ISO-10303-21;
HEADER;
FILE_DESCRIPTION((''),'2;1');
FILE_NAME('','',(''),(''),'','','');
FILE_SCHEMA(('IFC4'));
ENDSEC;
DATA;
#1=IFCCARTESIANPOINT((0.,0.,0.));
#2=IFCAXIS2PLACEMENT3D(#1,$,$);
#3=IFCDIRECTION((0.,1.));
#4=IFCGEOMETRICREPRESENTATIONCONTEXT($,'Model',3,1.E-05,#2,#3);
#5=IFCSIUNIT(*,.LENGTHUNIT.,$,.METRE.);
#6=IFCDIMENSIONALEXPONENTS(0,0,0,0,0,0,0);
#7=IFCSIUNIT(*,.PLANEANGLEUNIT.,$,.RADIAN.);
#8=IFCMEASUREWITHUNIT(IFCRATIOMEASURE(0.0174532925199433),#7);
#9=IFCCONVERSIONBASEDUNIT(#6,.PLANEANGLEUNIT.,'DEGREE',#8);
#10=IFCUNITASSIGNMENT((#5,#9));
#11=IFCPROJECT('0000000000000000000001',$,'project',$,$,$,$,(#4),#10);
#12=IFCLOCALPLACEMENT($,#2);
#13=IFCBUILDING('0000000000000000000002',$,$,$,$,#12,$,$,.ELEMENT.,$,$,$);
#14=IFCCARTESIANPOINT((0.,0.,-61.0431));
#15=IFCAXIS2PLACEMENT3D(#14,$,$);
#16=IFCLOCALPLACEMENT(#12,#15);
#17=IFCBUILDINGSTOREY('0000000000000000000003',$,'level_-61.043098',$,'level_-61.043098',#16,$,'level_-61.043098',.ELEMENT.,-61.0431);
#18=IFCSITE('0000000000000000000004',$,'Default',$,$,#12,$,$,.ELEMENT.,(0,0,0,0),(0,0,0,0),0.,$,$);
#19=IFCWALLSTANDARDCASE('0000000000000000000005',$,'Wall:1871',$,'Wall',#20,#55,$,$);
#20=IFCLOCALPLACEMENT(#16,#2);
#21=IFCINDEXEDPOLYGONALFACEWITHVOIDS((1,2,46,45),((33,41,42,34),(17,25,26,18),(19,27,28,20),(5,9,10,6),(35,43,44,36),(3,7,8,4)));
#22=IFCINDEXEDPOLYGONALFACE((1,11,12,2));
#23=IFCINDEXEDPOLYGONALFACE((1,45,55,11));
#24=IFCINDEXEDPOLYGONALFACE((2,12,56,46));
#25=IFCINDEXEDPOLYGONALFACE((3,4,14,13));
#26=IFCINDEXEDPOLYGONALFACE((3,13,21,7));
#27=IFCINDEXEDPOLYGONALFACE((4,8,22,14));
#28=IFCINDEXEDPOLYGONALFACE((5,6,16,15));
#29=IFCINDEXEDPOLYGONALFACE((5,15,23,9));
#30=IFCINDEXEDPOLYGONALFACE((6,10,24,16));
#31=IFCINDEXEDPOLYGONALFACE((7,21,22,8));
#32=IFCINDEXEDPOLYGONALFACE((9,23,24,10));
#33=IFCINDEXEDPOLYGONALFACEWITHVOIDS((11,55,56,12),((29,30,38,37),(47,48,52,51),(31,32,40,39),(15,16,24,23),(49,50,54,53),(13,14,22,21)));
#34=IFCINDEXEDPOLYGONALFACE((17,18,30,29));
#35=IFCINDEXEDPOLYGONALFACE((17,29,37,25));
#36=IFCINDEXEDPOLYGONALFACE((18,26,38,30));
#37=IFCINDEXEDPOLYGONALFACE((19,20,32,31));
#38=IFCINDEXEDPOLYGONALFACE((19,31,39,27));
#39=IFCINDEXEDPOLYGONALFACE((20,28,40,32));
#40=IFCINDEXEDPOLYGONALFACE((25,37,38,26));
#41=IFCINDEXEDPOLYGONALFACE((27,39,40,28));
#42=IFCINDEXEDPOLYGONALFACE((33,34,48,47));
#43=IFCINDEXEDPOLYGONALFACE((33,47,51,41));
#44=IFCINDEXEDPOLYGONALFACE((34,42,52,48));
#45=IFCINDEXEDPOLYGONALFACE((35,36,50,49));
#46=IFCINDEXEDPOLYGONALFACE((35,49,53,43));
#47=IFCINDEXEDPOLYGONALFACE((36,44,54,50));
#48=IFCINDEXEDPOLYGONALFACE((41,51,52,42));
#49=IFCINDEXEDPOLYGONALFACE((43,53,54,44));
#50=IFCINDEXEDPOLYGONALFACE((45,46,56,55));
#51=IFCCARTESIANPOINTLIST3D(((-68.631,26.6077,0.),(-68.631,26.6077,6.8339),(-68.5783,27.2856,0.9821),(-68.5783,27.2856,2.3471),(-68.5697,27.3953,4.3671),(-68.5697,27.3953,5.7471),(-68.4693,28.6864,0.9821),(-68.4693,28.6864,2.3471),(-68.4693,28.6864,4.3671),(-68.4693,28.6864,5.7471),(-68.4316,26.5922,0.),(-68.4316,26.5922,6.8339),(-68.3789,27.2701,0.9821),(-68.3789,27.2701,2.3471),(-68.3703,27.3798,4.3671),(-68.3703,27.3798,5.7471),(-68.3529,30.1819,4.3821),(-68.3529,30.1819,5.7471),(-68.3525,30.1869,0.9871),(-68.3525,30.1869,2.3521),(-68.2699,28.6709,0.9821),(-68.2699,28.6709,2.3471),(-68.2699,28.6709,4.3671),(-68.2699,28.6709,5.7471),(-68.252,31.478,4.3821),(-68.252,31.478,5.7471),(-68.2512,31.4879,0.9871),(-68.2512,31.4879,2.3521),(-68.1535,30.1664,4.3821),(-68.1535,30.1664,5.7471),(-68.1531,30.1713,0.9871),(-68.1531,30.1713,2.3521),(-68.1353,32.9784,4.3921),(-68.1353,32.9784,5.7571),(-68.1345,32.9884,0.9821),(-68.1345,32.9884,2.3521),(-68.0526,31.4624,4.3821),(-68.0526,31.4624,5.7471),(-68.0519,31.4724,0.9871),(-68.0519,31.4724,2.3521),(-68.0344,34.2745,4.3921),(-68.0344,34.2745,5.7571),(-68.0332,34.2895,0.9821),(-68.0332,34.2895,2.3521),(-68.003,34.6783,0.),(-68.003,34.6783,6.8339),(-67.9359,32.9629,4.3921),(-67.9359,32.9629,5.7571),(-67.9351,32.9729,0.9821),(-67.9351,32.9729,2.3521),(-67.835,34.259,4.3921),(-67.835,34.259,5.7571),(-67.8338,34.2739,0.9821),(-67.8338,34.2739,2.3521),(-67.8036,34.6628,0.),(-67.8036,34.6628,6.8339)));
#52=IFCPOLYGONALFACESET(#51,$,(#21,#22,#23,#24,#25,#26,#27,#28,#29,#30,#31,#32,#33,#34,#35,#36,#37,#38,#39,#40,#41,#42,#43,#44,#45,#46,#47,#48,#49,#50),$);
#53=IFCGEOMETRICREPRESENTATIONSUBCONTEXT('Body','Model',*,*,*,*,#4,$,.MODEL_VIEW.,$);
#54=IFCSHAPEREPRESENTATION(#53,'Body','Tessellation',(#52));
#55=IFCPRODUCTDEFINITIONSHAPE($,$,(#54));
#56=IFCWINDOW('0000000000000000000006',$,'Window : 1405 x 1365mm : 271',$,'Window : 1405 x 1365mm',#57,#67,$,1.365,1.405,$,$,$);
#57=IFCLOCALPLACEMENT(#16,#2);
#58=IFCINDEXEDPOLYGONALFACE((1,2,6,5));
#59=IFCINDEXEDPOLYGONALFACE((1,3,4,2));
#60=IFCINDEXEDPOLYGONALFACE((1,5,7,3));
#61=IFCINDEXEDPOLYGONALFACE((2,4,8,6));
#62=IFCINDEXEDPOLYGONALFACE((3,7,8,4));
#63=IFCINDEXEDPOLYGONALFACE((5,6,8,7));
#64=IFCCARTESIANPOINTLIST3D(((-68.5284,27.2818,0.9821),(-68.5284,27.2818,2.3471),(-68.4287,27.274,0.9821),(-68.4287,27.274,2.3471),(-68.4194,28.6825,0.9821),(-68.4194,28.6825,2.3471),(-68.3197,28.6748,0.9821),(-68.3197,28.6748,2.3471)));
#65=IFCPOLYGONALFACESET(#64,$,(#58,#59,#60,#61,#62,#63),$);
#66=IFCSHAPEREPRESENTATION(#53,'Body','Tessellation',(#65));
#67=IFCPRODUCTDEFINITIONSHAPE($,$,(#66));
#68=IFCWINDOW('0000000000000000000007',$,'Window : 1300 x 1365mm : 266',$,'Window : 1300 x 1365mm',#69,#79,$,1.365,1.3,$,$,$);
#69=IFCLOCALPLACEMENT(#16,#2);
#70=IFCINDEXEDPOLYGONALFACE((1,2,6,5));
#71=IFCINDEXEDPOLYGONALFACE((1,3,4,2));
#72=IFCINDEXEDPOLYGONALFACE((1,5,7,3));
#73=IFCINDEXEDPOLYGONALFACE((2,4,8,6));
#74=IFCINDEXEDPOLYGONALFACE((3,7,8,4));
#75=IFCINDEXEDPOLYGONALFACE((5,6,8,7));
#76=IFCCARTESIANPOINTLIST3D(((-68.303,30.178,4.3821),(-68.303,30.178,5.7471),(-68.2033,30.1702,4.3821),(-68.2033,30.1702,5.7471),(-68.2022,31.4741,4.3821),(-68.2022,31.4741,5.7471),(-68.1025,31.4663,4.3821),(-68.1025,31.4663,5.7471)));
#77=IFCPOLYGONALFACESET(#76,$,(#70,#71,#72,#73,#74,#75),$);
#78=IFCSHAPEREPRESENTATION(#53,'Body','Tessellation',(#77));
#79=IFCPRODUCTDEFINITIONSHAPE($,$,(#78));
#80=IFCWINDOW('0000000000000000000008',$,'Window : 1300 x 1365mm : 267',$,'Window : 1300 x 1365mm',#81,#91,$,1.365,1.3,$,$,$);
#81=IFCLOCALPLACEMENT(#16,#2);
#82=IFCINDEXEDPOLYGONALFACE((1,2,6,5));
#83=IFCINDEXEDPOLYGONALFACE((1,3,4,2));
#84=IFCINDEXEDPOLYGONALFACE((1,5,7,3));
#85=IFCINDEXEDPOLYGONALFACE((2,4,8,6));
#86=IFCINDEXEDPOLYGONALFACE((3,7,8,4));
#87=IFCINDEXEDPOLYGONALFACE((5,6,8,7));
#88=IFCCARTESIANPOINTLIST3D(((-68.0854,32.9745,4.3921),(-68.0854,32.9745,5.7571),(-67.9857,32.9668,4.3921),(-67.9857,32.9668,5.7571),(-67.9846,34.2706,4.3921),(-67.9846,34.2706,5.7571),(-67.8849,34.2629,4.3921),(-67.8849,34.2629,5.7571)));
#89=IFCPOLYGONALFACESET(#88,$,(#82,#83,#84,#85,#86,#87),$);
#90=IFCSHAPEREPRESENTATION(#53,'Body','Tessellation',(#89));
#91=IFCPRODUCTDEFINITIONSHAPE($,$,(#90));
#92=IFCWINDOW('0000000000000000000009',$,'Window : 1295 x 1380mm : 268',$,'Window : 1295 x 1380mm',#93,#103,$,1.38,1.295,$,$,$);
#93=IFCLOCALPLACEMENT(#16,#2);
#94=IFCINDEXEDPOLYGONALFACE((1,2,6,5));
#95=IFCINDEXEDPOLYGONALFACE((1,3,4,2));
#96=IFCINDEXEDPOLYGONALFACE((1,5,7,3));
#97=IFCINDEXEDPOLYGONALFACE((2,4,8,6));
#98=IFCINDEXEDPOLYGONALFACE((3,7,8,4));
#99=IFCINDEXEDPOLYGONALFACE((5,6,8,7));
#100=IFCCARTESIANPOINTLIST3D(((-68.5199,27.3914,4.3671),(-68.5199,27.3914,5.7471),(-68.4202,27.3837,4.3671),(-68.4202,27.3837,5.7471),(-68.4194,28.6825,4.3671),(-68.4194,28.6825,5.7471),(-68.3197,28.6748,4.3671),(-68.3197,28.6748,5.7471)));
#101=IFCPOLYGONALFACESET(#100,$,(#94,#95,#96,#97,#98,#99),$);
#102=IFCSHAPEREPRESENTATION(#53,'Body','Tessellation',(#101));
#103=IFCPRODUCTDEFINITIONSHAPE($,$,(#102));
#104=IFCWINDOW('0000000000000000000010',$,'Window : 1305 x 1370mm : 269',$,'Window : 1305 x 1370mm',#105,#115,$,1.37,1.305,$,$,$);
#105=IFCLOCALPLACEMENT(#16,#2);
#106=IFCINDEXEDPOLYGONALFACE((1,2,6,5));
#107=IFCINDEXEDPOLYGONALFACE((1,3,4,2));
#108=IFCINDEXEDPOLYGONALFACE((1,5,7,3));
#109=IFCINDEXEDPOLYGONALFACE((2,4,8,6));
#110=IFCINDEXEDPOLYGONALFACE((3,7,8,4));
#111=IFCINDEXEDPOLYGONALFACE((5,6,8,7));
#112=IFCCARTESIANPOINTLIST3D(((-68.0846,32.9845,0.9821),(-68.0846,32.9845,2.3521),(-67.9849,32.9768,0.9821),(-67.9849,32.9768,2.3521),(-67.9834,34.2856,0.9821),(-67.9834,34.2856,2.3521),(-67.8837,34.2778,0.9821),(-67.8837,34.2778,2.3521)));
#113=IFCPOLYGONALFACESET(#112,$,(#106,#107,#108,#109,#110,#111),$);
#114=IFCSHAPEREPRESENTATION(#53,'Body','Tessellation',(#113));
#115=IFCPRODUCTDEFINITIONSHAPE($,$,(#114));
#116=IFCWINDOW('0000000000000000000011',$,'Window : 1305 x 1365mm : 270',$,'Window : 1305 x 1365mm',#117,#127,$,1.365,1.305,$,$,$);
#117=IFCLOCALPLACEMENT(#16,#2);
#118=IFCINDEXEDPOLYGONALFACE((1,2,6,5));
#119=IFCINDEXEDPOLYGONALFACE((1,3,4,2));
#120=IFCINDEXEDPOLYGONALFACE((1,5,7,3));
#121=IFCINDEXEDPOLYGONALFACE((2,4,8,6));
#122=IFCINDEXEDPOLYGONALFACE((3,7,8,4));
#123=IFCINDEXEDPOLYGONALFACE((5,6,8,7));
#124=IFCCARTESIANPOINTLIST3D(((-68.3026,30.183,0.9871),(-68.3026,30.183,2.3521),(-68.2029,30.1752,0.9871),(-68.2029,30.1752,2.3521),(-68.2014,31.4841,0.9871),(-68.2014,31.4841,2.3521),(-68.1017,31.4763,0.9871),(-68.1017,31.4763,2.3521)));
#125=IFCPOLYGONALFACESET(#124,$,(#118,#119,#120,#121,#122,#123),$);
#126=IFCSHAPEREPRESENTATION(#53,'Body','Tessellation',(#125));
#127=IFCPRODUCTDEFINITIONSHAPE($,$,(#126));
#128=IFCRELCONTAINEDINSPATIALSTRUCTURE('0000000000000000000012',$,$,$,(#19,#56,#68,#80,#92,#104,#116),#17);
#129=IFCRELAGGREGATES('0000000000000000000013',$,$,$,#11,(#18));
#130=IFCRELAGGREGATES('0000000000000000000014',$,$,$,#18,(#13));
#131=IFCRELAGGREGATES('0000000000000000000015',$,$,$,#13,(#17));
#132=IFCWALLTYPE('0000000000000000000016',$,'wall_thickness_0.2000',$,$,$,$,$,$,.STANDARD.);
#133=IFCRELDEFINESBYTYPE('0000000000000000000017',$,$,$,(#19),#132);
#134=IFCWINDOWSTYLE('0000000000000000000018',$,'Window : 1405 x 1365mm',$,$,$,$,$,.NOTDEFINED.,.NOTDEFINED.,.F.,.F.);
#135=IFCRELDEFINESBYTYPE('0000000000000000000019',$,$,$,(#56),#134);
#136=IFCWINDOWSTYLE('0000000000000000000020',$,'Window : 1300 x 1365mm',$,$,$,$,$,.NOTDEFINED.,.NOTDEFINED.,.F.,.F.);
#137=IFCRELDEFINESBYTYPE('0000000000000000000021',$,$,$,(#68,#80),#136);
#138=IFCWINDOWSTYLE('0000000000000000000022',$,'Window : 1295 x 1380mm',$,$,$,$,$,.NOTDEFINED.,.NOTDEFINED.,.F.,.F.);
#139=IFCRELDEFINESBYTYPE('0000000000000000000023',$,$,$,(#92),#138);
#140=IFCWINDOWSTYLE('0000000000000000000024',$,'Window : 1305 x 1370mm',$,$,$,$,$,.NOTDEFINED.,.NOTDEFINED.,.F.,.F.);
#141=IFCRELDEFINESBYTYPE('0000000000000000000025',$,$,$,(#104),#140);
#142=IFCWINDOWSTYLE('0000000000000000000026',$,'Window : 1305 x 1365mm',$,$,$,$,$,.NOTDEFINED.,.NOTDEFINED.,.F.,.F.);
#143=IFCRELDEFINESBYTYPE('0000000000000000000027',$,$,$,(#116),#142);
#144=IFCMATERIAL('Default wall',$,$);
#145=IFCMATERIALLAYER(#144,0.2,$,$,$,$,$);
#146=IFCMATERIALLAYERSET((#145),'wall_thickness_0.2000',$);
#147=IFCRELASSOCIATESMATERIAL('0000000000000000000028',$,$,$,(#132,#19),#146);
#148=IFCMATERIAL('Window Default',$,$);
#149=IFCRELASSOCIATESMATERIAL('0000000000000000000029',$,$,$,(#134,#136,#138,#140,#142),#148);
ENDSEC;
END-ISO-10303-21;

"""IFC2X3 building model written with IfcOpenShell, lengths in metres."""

from ifc_helpers import new_model, entity, si_unit, converted_unit, direction, frame, frame_2d, origin, origin_2d_with_axis, place, context, subcontext, project, spatial, polyline, rectangle, outline, extrude, source, transform, mapped, material, layer, layer_set, layer_usage, type_object, type_shapes, element, fill, save


model = new_model("IFC2X3")

# Units and contexts
model_context = context("Model", 3, precision=1e-05, world=origin(), true_north=direction((0.0, 1.0)))
body_context = subcontext(model_context, "Body", "Model", "MODEL_VIEW")
ifc_project = project(units=[si_unit("LENGTHUNIT", "METRE"), converted_unit("PLANEANGLEUNIT", "DEGREE", entity("IfcRatioMeasure", 0.0174532925199433), si_unit("PLANEANGLEUNIT", "RADIAN"), dimensions=[0, 0, 0, 0, 0, 0, 0])], contexts=[model_context])

# Site, building, storey
placement_1 = place(None, origin())
site = spatial("IfcSite", under=ifc_project, at=placement_1, Name="Default", CompositionType="ELEMENT", RefLatitude=(0, 0, 0, 0), RefLongitude=(0, 0, 0, 0), RefElevation=0.0)
building = spatial("IfcBuilding", under=site, at=placement_1, CompositionType="ELEMENT")
storey_placement = place(placement_1, frame((0.0, 0.0, -61.0431)))
storey = spatial("IfcBuildingStorey", under=building, at=storey_placement, Name="level_-61.043098", ObjectType="level_-61.043098", LongName="level_-61.043098", CompositionType="ELEMENT", Elevation=-61.0431)

# Shared definitions
ifc_material_1 = material(Name="Default wall")
ifc_layer = layer(ifc_material_1, 0.2)
ifc_layer_set = layer_set([ifc_layer], Name="wall_thickness_0.2000")
ifc_layer_usage = layer_usage(ifc_layer_set, "AXIS2", "POSITIVE", -0.1)
wall_type = type_object("IfcWallType", Name="wall_thickness_0.2000", PredefinedType="STANDARD", material=ifc_layer_set)

# Shared definitions
ifc_material_2 = material(Name="Window Default")

# Wall, openings, windows
wall_1_placement = place(storey_placement, frame((-67.9033, 34.6705, 0.0), z_axis=(0.0, 0.0, 1.0), x_axis=(-0.077582, -0.996986, 0.0)))
wall_1 = element("IfcWallStandardCase", 1, at=wall_1_placement, inside=storey, type_object=wall_type, material=ifc_layer_usage, Name="Wall:1871", ObjectType="Wall", context=body_context, shape_type="SweptSolid", body=[
    extrude(outline(polyline([(8.095, -0.1), (8.095, 0.1), (0.0, 0.1), (0.0, -0.1), (8.095, -0.1)])), origin(), (0.0, 0.0, 1.0), 6.8339),
])
opening_1_placement = place(wall_1_placement, frame((3.21, -0.1, 4.3821)))
opening_1 = element("IfcOpeningElement", 2, at=opening_1_placement, cuts=wall_1, ObjectType="Opening", context=body_context, shape_type="SweptSolid", body=[
    extrude(rectangle(XDim=1.3, YDim=1.365, at=frame_2d((0.6825, 0.65), x_axis=(0.0, 1.0))), frame((0.0, 0.0, 0.0), z_axis=(0.0, 1.0, 0.0), x_axis=(0.0, 0.0, 1.0)), (0.0, 0.0, 1.0), 0.2),
])
opening_2_placement = place(wall_1_placement, frame((0.405, -0.1, 4.3921)))
opening_2 = element("IfcOpeningElement", 3, at=opening_2_placement, cuts=wall_1, ObjectType="Opening", context=body_context, shape_type="SweptSolid", body=[
    extrude(rectangle(XDim=1.3, YDim=1.365, at=frame_2d((0.6825, 0.65), x_axis=(0.0, 1.0))), frame((0.0, 0.0, 0.0), z_axis=(0.0, 1.0, 0.0), x_axis=(0.0, 0.0, 1.0)), (0.0, 0.0, 1.0), 0.2),
])
opening_3_placement = place(wall_1_placement, frame((6.01, -0.1, 4.3671)))
opening_3 = element("IfcOpeningElement", 4, at=opening_3_placement, cuts=wall_1, ObjectType="Opening", context=body_context, shape_type="SweptSolid", body=[
    extrude(rectangle(XDim=1.295, YDim=1.38, at=frame_2d((0.69, 0.6475), x_axis=(0.0, 1.0))), frame((0.0, 0.0, 0.0), z_axis=(0.0, 1.0, 0.0), x_axis=(0.0, 0.0, 1.0)), (0.0, 0.0, 1.0), 0.2),
])
opening_4_placement = place(wall_1_placement, frame((0.39, -0.1, 0.9821)))
opening_4 = element("IfcOpeningElement", 5, at=opening_4_placement, cuts=wall_1, ObjectType="Opening", context=body_context, shape_type="SweptSolid", body=[
    extrude(rectangle(XDim=1.305, YDim=1.37, at=frame_2d((0.685, 0.6525), x_axis=(0.0, 1.0))), frame((0.0, 0.0, 0.0), z_axis=(0.0, 1.0, 0.0), x_axis=(0.0, 0.0, 1.0)), (0.0, 0.0, 1.0), 0.2),
])
opening_5_placement = place(wall_1_placement, frame((3.2, -0.1, 0.9871)))
opening_5 = element("IfcOpeningElement", 6, at=opening_5_placement, cuts=wall_1, ObjectType="Opening", context=body_context, shape_type="SweptSolid", body=[
    extrude(rectangle(XDim=1.305, YDim=1.365, at=frame_2d((0.6825, 0.6525), x_axis=(0.0, 1.0))), frame((0.0, 0.0, 0.0), z_axis=(0.0, 1.0, 0.0), x_axis=(0.0, 0.0, 1.0)), (0.0, 0.0, 1.0), 0.2),
])
opening_6_placement = place(wall_1_placement, frame((6.01, -0.1, 0.9821)))
opening_6 = element("IfcOpeningElement", 7, at=opening_6_placement, cuts=wall_1, ObjectType="Opening", context=body_context, shape_type="SweptSolid", body=[
    extrude(rectangle(XDim=1.405, YDim=1.365, at=frame_2d((0.6825, 0.7025), x_axis=(0.0, 1.0))), frame((0.0, 0.0, 0.0), z_axis=(0.0, 1.0, 0.0), x_axis=(0.0, 0.0, 1.0)), (0.0, 0.0, 1.0), 0.2),
])
window_style_1 = type_object("IfcWindowStyle", Name="Window : 1405 x 1365mm", ConstructionType="NOTDEFINED", OperationType="NOTDEFINED", ParameterTakesPrecedence=False, Sizeable=False, material=ifc_material_2)
shared_shape_1 = source(origin(), body_context, "Body", "SweptSolid", [
    extrude(rectangle(XDim=0.1, YDim=1.405, at=origin_2d_with_axis()), frame((0.7025, 0.1, 0.0), z_axis=(0.0, 0.0, 1.0), x_axis=(0.0, 1.0, 0.0)), (0.0, 0.0, 1.0), 1.365),
])
type_shapes(window_style_1, [shared_shape_1])
window_1_placement = place(opening_6_placement, origin())
window_1 = element("IfcWindow", 8, at=window_1_placement, inside=storey, type_object=window_style_1, Name="Window : 1405 x 1365mm : 271", ObjectType="Window : 1405 x 1365mm", OverallHeight=1.365, OverallWidth=1.405, context=body_context, shape_type="MappedRepresentation", body=[
    mapped(shared_shape_1, transform((0.0, 0.0, 0.0), scale=1.0)),
])
fill(opening_6, window_1)
window_style_2 = type_object("IfcWindowStyle", Name="Window : 1300 x 1365mm", ConstructionType="NOTDEFINED", OperationType="NOTDEFINED", ParameterTakesPrecedence=False, Sizeable=False, material=ifc_material_2)
shared_shape_2 = source(origin(), body_context, "Body", "SweptSolid", [
    extrude(rectangle(XDim=0.1, YDim=1.3, at=origin_2d_with_axis()), frame((0.65, 0.1, 0.0), z_axis=(0.0, 0.0, 1.0), x_axis=(0.0, 1.0, 0.0)), (0.0, 0.0, 1.0), 1.365),
])
type_shapes(window_style_2, [shared_shape_2])
window_2_placement = place(opening_1_placement, origin())
window_2 = element("IfcWindow", 9, at=window_2_placement, inside=storey, type_object=window_style_2, Name="Window : 1300 x 1365mm : 266", ObjectType="Window : 1300 x 1365mm", OverallHeight=1.365, OverallWidth=1.3, context=body_context, shape_type="MappedRepresentation", body=[
    mapped(shared_shape_2, transform((0.0, 0.0, 0.0), scale=1.0)),
])
fill(opening_1, window_2)
window_3_placement = place(opening_2_placement, origin())
window_3 = element("IfcWindow", 10, at=window_3_placement, inside=storey, type_object=window_style_2, Name="Window : 1300 x 1365mm : 267", ObjectType="Window : 1300 x 1365mm", OverallHeight=1.365, OverallWidth=1.3, context=body_context, shape_type="MappedRepresentation", body=[
    mapped(shared_shape_2, transform((0.0, 0.0, 0.0), scale=1.0)),
])
fill(opening_2, window_3)
window_style_3 = type_object("IfcWindowStyle", Name="Window : 1295 x 1380mm", ConstructionType="NOTDEFINED", OperationType="NOTDEFINED", ParameterTakesPrecedence=False, Sizeable=False, material=ifc_material_2)
shared_shape_3 = source(origin(), body_context, "Body", "SweptSolid", [
    extrude(rectangle(XDim=0.1, YDim=1.295, at=origin_2d_with_axis()), frame((0.6475, 0.1, 0.0), z_axis=(0.0, 0.0, 1.0), x_axis=(0.0, 1.0, 0.0)), (0.0, 0.0, 1.0), 1.38),
])
type_shapes(window_style_3, [shared_shape_3])
window_4_placement = place(opening_3_placement, origin())
window_4 = element("IfcWindow", 11, at=window_4_placement, inside=storey, type_object=window_style_3, Name="Window : 1295 x 1380mm : 268", ObjectType="Window : 1295 x 1380mm", OverallHeight=1.38, OverallWidth=1.295, context=body_context, shape_type="MappedRepresentation", body=[
    mapped(shared_shape_3, transform((0.0, 0.0, 0.0), scale=1.0)),
])
fill(opening_3, window_4)
window_style_4 = type_object("IfcWindowStyle", Name="Window : 1305 x 1370mm", ConstructionType="NOTDEFINED", OperationType="NOTDEFINED", ParameterTakesPrecedence=False, Sizeable=False, material=ifc_material_2)
shared_shape_4 = source(origin(), body_context, "Body", "SweptSolid", [
    extrude(rectangle(XDim=0.1, YDim=1.305, at=origin_2d_with_axis()), frame((0.6525, 0.1, 0.0), z_axis=(0.0, 0.0, 1.0), x_axis=(0.0, 1.0, 0.0)), (0.0, 0.0, 1.0), 1.37),
])
type_shapes(window_style_4, [shared_shape_4])
window_5_placement = place(opening_4_placement, origin())
window_5 = element("IfcWindow", 12, at=window_5_placement, inside=storey, type_object=window_style_4, Name="Window : 1305 x 1370mm : 269", ObjectType="Window : 1305 x 1370mm", OverallHeight=1.37, OverallWidth=1.305, context=body_context, shape_type="MappedRepresentation", body=[
    mapped(shared_shape_4, transform((0.0, 0.0, 0.0), scale=1.0)),
])
fill(opening_4, window_5)
window_style_5 = type_object("IfcWindowStyle", Name="Window : 1305 x 1365mm", ConstructionType="NOTDEFINED", OperationType="NOTDEFINED", ParameterTakesPrecedence=False, Sizeable=False, material=ifc_material_2)
shared_shape_5 = source(origin(), body_context, "Body", "SweptSolid", [
    extrude(rectangle(XDim=0.1, YDim=1.305, at=origin_2d_with_axis()), frame((0.6525, 0.1, 0.0), z_axis=(0.0, 0.0, 1.0), x_axis=(0.0, 1.0, 0.0)), (0.0, 0.0, 1.0), 1.365),
])
type_shapes(window_style_5, [shared_shape_5])
window_6_placement = place(opening_5_placement, origin())
window_6 = element("IfcWindow", 13, at=window_6_placement, inside=storey, type_object=window_style_5, Name="Window : 1305 x 1365mm : 270", ObjectType="Window : 1305 x 1365mm", OverallHeight=1.365, OverallWidth=1.305, context=body_context, shape_type="MappedRepresentation", body=[
    mapped(shared_shape_5, transform((0.0, 0.0, 0.0), scale=1.0)),
])
fill(opening_5, window_6)

save(model, "model.ifc")
